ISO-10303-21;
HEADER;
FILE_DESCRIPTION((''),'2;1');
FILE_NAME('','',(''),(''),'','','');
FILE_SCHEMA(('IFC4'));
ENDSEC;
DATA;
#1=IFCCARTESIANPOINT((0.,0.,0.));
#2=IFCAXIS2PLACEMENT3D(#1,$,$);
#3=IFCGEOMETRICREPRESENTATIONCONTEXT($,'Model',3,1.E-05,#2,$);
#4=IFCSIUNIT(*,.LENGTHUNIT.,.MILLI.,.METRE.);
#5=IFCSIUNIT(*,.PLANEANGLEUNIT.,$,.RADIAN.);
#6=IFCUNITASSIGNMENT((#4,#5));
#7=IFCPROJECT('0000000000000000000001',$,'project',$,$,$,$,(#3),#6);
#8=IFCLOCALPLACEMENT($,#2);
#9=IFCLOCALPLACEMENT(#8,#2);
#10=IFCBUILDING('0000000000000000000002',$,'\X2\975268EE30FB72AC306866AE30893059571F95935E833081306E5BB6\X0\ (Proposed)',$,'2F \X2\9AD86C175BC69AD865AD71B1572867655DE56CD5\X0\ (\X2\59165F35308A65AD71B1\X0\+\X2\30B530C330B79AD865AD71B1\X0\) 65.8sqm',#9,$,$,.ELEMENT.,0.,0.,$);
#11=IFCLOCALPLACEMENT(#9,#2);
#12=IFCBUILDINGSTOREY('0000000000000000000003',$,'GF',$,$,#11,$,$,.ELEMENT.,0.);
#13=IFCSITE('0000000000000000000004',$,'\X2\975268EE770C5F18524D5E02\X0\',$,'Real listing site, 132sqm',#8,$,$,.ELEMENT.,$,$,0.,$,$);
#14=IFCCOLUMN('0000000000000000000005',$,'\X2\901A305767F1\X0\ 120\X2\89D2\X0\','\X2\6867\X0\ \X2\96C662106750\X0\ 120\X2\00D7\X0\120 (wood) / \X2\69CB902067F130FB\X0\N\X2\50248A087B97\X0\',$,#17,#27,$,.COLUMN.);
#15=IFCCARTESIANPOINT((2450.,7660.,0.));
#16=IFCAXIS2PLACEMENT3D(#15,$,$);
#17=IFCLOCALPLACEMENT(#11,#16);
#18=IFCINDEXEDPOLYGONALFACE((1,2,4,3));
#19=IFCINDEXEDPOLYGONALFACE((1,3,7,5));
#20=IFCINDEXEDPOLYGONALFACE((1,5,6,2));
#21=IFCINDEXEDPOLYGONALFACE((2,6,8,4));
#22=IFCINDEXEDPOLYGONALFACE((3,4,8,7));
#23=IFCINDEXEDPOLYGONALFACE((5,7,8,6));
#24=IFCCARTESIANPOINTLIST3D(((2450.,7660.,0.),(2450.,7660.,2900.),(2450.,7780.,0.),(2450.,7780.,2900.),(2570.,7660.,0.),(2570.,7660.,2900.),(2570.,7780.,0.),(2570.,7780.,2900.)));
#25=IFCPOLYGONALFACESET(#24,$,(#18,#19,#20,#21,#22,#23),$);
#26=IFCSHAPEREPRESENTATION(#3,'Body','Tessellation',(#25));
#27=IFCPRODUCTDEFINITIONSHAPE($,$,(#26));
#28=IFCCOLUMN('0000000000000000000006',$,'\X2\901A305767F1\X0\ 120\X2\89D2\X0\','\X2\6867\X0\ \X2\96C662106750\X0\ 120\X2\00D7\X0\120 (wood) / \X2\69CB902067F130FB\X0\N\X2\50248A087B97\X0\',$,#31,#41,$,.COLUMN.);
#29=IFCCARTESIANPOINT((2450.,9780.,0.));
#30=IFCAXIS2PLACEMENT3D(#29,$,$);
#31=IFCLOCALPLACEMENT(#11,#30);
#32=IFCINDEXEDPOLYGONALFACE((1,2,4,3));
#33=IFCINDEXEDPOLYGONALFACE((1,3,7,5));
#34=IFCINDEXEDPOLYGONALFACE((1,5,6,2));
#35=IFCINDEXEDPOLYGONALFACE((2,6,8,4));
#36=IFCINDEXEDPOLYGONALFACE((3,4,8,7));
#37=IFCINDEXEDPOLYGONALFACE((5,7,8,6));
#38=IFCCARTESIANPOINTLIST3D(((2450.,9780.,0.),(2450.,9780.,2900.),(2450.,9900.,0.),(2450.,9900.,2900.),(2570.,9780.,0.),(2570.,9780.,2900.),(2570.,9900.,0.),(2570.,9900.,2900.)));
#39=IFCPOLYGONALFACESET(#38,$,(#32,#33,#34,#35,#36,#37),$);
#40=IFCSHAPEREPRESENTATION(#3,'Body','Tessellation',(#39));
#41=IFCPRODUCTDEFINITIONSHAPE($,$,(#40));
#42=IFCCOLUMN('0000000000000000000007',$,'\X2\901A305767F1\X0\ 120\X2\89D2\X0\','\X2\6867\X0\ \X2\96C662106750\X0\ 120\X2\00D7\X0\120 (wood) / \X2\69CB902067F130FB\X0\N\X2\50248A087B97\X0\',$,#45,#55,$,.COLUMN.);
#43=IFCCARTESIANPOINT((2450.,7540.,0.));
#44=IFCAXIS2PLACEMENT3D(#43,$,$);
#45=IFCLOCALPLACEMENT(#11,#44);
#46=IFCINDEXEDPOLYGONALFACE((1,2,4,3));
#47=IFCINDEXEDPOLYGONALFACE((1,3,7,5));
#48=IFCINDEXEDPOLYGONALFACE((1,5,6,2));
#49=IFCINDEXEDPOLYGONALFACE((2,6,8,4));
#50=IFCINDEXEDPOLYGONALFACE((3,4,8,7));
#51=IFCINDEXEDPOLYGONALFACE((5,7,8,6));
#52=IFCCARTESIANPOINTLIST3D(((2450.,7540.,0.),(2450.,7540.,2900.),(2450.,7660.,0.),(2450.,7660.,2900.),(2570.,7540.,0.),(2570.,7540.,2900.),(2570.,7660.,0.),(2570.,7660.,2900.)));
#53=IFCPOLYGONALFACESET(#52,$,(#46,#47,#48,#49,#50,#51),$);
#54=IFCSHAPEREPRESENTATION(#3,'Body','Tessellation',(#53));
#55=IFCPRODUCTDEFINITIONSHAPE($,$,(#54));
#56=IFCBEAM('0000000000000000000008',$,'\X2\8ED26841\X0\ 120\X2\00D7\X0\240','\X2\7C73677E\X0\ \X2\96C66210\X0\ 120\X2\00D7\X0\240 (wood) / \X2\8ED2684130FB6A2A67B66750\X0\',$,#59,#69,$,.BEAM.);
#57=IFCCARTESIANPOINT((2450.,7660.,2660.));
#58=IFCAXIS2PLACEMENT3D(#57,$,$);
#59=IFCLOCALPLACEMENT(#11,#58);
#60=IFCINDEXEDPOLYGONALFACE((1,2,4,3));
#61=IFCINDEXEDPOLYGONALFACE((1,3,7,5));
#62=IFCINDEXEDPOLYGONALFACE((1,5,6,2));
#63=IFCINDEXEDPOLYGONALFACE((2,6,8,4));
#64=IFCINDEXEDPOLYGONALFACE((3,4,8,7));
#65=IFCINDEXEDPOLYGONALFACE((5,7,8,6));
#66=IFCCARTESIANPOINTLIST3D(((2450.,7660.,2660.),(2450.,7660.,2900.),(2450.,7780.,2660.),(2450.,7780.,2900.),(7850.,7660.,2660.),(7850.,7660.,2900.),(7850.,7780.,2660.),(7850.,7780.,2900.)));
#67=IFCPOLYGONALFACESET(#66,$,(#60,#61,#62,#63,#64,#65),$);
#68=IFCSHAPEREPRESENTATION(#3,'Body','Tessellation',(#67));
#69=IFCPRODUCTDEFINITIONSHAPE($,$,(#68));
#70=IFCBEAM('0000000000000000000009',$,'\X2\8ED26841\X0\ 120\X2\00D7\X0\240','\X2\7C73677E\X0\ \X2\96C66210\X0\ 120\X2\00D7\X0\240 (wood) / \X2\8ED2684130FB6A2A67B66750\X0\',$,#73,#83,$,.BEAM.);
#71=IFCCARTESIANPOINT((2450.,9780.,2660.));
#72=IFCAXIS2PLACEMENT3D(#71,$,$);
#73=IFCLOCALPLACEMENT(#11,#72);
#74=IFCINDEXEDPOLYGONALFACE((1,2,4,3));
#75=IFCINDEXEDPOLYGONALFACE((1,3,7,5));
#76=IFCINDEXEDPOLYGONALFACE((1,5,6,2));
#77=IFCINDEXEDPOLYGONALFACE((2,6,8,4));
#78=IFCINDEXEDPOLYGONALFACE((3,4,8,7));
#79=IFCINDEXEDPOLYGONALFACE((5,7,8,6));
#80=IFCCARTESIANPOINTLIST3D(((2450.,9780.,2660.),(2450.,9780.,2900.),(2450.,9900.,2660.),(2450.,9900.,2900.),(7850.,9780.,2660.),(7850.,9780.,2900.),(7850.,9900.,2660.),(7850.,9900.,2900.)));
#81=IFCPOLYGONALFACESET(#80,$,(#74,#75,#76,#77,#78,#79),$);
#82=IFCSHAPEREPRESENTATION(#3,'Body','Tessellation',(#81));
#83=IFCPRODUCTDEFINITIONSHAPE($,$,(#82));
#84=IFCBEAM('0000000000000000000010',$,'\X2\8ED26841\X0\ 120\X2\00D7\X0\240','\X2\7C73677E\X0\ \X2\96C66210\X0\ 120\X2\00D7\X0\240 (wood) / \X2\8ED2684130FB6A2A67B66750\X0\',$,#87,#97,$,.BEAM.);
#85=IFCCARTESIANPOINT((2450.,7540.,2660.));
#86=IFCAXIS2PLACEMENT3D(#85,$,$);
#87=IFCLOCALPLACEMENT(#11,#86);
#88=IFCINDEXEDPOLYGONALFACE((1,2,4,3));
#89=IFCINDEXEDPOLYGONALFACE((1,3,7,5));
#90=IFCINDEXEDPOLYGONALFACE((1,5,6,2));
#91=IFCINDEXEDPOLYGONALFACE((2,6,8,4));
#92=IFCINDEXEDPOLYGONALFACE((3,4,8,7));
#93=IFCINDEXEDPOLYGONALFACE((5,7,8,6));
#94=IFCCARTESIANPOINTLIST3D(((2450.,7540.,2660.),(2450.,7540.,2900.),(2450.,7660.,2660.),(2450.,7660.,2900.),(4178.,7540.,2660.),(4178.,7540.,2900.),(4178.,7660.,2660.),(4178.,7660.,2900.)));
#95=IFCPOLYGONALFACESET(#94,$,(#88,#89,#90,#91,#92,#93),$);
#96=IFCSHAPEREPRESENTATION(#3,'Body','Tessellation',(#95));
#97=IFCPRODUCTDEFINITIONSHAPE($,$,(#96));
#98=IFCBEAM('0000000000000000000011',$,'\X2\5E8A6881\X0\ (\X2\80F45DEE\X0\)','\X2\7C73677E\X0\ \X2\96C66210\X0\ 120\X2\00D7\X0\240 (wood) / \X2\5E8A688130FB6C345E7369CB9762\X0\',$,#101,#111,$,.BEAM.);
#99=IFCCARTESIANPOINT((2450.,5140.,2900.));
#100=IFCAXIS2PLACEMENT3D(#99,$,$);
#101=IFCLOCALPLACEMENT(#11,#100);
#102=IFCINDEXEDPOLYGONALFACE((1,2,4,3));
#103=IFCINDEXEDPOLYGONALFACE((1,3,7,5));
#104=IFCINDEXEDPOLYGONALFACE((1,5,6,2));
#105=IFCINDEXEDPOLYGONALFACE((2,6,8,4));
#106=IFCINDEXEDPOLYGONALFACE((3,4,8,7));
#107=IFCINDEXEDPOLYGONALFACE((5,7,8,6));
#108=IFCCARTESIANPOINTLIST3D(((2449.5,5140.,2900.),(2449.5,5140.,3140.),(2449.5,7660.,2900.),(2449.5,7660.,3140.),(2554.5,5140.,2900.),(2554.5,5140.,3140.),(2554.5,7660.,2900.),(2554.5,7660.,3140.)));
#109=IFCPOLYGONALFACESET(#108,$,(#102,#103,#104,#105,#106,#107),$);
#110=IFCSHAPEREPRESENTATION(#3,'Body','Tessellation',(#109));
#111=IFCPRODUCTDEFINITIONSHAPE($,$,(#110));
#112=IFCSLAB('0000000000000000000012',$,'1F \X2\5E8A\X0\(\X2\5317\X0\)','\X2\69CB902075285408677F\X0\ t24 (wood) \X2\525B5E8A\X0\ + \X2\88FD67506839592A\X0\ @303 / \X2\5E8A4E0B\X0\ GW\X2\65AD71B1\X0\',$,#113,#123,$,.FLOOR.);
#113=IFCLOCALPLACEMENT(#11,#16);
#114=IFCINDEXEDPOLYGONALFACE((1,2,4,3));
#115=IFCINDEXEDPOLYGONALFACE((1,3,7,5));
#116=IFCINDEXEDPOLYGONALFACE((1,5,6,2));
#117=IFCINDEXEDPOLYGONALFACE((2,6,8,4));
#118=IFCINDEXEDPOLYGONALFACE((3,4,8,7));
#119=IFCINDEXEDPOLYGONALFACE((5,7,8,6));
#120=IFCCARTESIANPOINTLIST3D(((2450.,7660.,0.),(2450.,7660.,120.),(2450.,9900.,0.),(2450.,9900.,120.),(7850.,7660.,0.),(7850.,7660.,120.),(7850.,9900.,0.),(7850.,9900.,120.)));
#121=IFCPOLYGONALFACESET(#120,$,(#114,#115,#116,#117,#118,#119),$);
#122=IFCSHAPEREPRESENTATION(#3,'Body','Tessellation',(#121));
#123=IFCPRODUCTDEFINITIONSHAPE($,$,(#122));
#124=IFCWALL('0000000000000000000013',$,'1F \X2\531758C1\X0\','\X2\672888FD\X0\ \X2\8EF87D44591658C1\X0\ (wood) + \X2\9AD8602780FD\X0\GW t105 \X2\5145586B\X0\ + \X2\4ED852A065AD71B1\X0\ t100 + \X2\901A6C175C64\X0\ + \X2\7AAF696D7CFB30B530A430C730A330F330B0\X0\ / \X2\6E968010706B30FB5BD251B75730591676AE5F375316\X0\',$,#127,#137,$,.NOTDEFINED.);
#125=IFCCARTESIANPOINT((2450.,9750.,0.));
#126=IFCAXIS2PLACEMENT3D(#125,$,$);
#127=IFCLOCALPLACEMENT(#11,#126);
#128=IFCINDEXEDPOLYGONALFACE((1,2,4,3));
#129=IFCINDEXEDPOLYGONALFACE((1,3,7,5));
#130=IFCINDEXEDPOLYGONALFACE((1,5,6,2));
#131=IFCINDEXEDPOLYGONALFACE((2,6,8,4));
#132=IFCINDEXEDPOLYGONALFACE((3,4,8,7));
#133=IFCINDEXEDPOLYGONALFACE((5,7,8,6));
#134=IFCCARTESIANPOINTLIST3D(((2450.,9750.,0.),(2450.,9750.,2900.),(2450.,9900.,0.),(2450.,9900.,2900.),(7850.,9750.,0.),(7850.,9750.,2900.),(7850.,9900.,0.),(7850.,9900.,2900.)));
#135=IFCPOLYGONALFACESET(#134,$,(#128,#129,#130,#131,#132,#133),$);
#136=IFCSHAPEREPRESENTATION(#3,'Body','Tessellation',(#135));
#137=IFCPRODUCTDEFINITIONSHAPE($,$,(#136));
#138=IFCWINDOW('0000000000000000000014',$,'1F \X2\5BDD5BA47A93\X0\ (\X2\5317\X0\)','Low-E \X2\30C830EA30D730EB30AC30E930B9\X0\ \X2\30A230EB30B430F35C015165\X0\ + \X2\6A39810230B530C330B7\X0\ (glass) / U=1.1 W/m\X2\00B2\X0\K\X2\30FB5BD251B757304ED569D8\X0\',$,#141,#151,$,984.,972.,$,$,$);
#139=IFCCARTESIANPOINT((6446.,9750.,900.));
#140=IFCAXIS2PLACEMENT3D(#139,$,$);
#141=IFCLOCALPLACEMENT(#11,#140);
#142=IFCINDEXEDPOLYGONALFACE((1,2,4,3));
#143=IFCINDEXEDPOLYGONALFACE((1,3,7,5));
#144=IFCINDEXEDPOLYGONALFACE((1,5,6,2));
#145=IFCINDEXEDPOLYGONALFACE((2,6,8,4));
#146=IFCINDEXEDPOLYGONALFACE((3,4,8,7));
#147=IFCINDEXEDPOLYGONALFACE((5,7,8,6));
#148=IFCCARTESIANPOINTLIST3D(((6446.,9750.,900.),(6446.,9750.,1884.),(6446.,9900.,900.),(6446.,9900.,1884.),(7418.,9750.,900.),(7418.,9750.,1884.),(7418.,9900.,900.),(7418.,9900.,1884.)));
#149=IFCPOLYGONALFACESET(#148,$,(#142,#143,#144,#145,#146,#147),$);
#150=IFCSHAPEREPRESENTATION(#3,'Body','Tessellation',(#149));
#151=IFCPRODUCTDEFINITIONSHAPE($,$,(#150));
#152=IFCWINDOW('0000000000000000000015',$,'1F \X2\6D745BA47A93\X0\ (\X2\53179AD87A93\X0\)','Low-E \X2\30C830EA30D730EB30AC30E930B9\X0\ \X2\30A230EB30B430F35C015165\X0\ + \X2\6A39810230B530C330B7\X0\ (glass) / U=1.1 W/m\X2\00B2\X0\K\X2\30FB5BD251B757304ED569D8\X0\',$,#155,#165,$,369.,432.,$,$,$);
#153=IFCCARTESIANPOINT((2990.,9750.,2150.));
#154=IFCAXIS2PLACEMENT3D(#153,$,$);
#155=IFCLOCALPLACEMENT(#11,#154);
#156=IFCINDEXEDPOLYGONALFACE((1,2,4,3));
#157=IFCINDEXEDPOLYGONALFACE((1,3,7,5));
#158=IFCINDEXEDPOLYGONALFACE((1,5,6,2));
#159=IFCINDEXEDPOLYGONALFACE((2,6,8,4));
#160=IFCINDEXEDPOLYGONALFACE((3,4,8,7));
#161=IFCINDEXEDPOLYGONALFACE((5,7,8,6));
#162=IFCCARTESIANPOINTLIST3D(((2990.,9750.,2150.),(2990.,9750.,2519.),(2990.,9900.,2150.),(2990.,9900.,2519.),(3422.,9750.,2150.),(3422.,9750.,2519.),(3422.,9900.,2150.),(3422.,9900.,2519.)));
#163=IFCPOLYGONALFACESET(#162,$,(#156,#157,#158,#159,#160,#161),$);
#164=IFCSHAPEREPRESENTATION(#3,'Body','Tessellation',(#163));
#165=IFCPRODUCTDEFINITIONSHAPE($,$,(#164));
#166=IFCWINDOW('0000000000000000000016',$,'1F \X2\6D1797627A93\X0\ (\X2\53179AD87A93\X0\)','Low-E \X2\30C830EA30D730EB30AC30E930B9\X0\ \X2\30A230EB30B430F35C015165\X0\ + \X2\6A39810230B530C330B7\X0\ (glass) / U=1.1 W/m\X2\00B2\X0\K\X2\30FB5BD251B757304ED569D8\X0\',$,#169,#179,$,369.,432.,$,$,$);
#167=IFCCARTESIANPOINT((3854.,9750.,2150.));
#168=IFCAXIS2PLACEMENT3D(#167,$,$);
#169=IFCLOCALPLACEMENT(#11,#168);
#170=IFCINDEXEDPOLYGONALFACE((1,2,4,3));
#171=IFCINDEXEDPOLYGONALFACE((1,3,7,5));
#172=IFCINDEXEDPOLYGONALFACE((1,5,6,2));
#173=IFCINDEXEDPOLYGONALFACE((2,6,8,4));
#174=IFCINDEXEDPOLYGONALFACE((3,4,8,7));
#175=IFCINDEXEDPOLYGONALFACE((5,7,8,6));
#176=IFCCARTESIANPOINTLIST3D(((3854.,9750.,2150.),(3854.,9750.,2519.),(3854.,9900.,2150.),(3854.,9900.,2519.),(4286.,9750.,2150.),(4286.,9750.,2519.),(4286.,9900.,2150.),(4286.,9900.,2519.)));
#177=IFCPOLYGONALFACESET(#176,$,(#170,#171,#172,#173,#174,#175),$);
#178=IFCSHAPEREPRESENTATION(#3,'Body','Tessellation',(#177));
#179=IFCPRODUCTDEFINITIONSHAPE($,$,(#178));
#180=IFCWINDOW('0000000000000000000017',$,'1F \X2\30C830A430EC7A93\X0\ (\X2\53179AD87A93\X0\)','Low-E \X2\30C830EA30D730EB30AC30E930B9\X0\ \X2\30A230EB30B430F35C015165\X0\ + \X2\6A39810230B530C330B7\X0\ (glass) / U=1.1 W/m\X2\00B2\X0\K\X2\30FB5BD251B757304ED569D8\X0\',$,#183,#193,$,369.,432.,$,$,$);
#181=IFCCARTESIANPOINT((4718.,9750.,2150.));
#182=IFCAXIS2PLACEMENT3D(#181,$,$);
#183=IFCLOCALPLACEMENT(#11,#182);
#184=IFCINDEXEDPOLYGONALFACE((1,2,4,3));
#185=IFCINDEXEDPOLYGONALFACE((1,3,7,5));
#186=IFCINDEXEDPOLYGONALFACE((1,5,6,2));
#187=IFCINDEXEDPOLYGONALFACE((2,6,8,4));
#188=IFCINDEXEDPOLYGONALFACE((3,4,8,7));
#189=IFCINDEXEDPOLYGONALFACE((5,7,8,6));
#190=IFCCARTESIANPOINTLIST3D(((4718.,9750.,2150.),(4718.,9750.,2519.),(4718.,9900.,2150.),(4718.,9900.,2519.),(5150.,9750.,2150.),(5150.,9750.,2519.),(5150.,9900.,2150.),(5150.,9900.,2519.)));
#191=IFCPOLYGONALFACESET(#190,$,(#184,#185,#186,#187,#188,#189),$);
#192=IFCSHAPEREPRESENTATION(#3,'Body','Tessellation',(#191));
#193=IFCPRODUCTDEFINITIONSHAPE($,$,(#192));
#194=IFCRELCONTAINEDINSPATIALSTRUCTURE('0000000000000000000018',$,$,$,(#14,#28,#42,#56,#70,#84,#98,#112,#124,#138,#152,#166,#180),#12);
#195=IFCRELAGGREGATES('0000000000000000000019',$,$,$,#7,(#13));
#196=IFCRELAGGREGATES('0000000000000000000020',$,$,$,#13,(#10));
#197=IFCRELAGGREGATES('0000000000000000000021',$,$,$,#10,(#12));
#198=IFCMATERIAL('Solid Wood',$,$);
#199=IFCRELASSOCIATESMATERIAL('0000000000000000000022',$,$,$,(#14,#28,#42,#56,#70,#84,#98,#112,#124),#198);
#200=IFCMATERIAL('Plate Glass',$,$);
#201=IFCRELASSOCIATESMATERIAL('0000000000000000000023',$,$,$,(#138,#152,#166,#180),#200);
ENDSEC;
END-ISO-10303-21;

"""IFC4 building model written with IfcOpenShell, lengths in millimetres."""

from ifc_helpers import new_model, si_unit, frame, frame_2d, origin, place, context, project, spatial, rectangle, extrude, material, element, fill, save


model = new_model("IFC4")

# Units and contexts
model_context = context("Model", 3, precision=1e-05, world=origin())
ifc_project = project(units=[si_unit("LENGTHUNIT", "METRE", prefix="MILLI"), si_unit("PLANEANGLEUNIT", "RADIAN")], contexts=[model_context])

# Site, building, storey
site_placement = place(None, origin())
site = spatial("IfcSite", under=ifc_project, at=site_placement, Name="青森県弘前市", ObjectType="Real listing site, 132sqm", CompositionType="ELEMENT", RefElevation=0.0)
building_placement = place(site_placement, origin())
building = spatial("IfcBuilding", under=site, at=building_placement, Name="青森・犬と暮らす土間広めの家 (Proposed)", ObjectType="2F 高気密高断熱在来工法 (外張り断熱+サッシ高断熱) 65.8sqm", CompositionType="ELEMENT", ElevationOfRefHeight=0.0, ElevationOfTerrain=0.0)
storey_placement = place(building_placement, origin())
storey = spatial("IfcBuildingStorey", under=building, at=storey_placement, Name="GF", CompositionType="ELEMENT", Elevation=0.0)

# Columns
ifc_material_1 = material(Name="Solid Wood")
column_1_placement = place(storey_placement, frame((2450.0, 7660.0, 0.0)))
element("IfcColumn", 1, at=column_1_placement, inside=storey, material=ifc_material_1, Name="通し柱 120角", Description="桧 集成材 120×120 (wood) / 構造柱・N値計算", PredefinedType="COLUMN", context=model_context, shape_type="SweptSolid", body=[
    extrude(rectangle(XDim=120.0, YDim=120.0, at=frame_2d((60.0, 60.0))), frame((2450.0, 7660.0, 0.0)), (0.0, 0.0, 1.0), 2900.0),
])
column_2_placement = place(storey_placement, frame((2450.0, 9780.0, 0.0)))
element("IfcColumn", 2, at=column_2_placement, inside=storey, material=ifc_material_1, Name="通し柱 120角", Description="桧 集成材 120×120 (wood) / 構造柱・N値計算", PredefinedType="COLUMN", context=model_context, shape_type="SweptSolid", body=[
    extrude(rectangle(XDim=120.0, YDim=120.0, at=frame_2d((60.0, 60.0))), frame((2450.0, 9780.0, 0.0)), (0.0, 0.0, 1.0), 2900.0),
])
column_3_placement = place(storey_placement, frame((2450.0, 7540.0, 0.0)))
element("IfcColumn", 3, at=column_3_placement, inside=storey, material=ifc_material_1, Name="通し柱 120角", Description="桧 集成材 120×120 (wood) / 構造柱・N値計算", PredefinedType="COLUMN", context=model_context, shape_type="SweptSolid", body=[
    extrude(rectangle(XDim=120.0, YDim=120.0, at=frame_2d((60.0, 60.0))), frame((2450.0, 7540.0, 0.0)), (0.0, 0.0, 1.0), 2900.0),
])

# Beams
beam_1_placement = place(storey_placement, frame((2450.0, 7660.0, 2660.0)))
element("IfcBeam", 4, at=beam_1_placement, inside=storey, material=ifc_material_1, Name="軒桁 120×240", Description="米松 集成 120×240 (wood) / 軒桁・横架材", PredefinedType="BEAM", context=model_context, shape_type="SweptSolid", body=[
    extrude(rectangle(XDim=5400.0, YDim=120.0, at=frame_2d((2700.0, 60.0))), frame((2450.0, 7660.0, 2660.0)), (0.0, 0.0, 1.0), 240.0),
])
beam_2_placement = place(storey_placement, frame((2450.0, 9780.0, 2660.0)))
element("IfcBeam", 5, at=beam_2_placement, inside=storey, material=ifc_material_1, Name="軒桁 120×240", Description="米松 集成 120×240 (wood) / 軒桁・横架材", PredefinedType="BEAM", context=model_context, shape_type="SweptSolid", body=[
    extrude(rectangle(XDim=5400.0, YDim=120.0, at=frame_2d((2700.0, 60.0))), frame((2450.0, 9780.0, 2660.0)), (0.0, 0.0, 1.0), 240.0),
])
beam_3_placement = place(storey_placement, frame((2450.0, 7540.0, 2660.0)))
element("IfcBeam", 6, at=beam_3_placement, inside=storey, material=ifc_material_1, Name="軒桁 120×240", Description="米松 集成 120×240 (wood) / 軒桁・横架材", PredefinedType="BEAM", context=model_context, shape_type="SweptSolid", body=[
    extrude(rectangle(XDim=1728.0, YDim=120.0, at=frame_2d((864.0, 60.0))), frame((2450.0, 7540.0, 2660.0)), (0.0, 0.0, 1.0), 240.0),
])
beam_4_placement = place(storey_placement, frame((2450.0, 5140.0, 2900.0)))
element("IfcBeam", 7, at=beam_4_placement, inside=storey, material=ifc_material_1, Name="床梁 (胴差)", Description="米松 集成 120×240 (wood) / 床梁・水平構面", PredefinedType="BEAM", context=model_context, shape_type="SweptSolid", body=[
    extrude(rectangle(XDim=105.0, YDim=2520.0, at=frame_2d((52.0, 1260.0))), frame((2450.0, 5140.0, 2900.0)), (0.0, 0.0, 1.0), 240.0),
])

# Slab
slab_placement = place(storey_placement, frame((2450.0, 7660.0, 0.0)))
element("IfcSlab", 8, at=slab_placement, inside=storey, material=ifc_material_1, Name="1F 床(北)", Description="構造用合板 t24 (wood) 剛床 + 製材根太 @303 / 床下 GW断熱", PredefinedType="FLOOR", context=model_context, shape_type="SweptSolid", body=[
    extrude(rectangle(XDim=5400.0, YDim=2240.0, at=frame_2d((2700.0, 1120.0))), frame((2450.0, 7660.0, 0.0)), (0.0, 0.0, 1.0), 120.0),
])

# Wall, openings, windows
wall_1_placement = place(storey_placement, frame((2450.0, 9750.0, 0.0)))
wall_1 = element("IfcWall", 9, at=wall_1_placement, inside=storey, material=ifc_material_1, Name="1F 北壁", Description="木製 軸組外壁 (wood) + 高性能GW t105 充填 + 付加断熱 t100 + 通気層 + 窯業系サイディング / 準耐火・寒冷地外皮強化", PredefinedType="NOTDEFINED", context=model_context, shape_type="SweptSolid", body=[
    extrude(rectangle(XDim=5400.0, YDim=150.0, at=frame_2d((2700.0, 75.0))), frame((2450.0, 9750.0, 0.0)), (0.0, 0.0, 1.0), 2900.0),
])
opening_1_placement = place(storey_placement, frame((6446.0, 9750.0, 900.0)))
opening_1 = element("IfcOpeningElement", 10, at=opening_1_placement, cuts=wall_1, PredefinedType="NOTDEFINED", context=model_context, shape_type="SweptSolid", body=[
    extrude(rectangle(XDim=972.0, YDim=150.0, at=frame_2d((486.0, 75.0))), frame((6446.0, 9750.0, 900.0)), (0.0, 0.0, 1.0), 984.0),
])
opening_2_placement = place(storey_placement, frame((2990.0, 9750.0, 2150.0)))
opening_2 = element("IfcOpeningElement", 11, at=opening_2_placement, cuts=wall_1, PredefinedType="NOTDEFINED", context=model_context, shape_type="SweptSolid", body=[
    extrude(rectangle(XDim=432.0, YDim=150.0, at=frame_2d((216.0, 75.0))), frame((2990.0, 9750.0, 2150.0)), (0.0, 0.0, 1.0), 369.0),
])
opening_3_placement = place(storey_placement, frame((3854.0, 9750.0, 2150.0)))
opening_3 = element("IfcOpeningElement", 12, at=opening_3_placement, cuts=wall_1, PredefinedType="NOTDEFINED", context=model_context, shape_type="SweptSolid", body=[
    extrude(rectangle(XDim=432.0, YDim=150.0, at=frame_2d((216.0, 75.0))), frame((3854.0, 9750.0, 2150.0)), (0.0, 0.0, 1.0), 369.0),
])
opening_4_placement = place(storey_placement, frame((4718.0, 9750.0, 2150.0)))
opening_4 = element("IfcOpeningElement", 13, at=opening_4_placement, cuts=wall_1, PredefinedType="NOTDEFINED", context=model_context, shape_type="SweptSolid", body=[
    extrude(rectangle(XDim=432.0, YDim=150.0, at=frame_2d((216.0, 75.0))), frame((4718.0, 9750.0, 2150.0)), (0.0, 0.0, 1.0), 369.0),
])
ifc_material_2 = material(Name="Plate Glass")
window_1_placement = place(storey_placement, frame((6446.0, 9750.0, 900.0)))
window_1 = element("IfcWindow", 14, at=window_1_placement, inside=storey, material=ifc_material_2, Name="1F 寝室窓 (北)", Description="Low-E トリプルガラス アルゴン封入 + 樹脂サッシ (glass) / U=1.1 W/m²K・寒冷地仕様", OverallHeight=984.0, OverallWidth=972.0, context=model_context, shape_type="SweptSolid", body=[
    extrude(rectangle(XDim=972.0, YDim=150.0, at=frame_2d((486.0, 75.0))), frame((6446.0, 9750.0, 900.0)), (0.0, 0.0, 1.0), 984.0),
])
fill(opening_1, window_1)
window_2_placement = place(storey_placement, frame((2990.0, 9750.0, 2150.0)))
window_2 = element("IfcWindow", 15, at=window_2_placement, inside=storey, material=ifc_material_2, Name="1F 浴室窓 (北高窓)", Description="Low-E トリプルガラス アルゴン封入 + 樹脂サッシ (glass) / U=1.1 W/m²K・寒冷地仕様", OverallHeight=369.0, OverallWidth=432.0, context=model_context, shape_type="SweptSolid", body=[
    extrude(rectangle(XDim=432.0, YDim=150.0, at=frame_2d((216.0, 75.0))), frame((2990.0, 9750.0, 2150.0)), (0.0, 0.0, 1.0), 369.0),
])
fill(opening_2, window_2)
window_3_placement = place(storey_placement, frame((3854.0, 9750.0, 2150.0)))
window_3 = element("IfcWindow", 16, at=window_3_placement, inside=storey, material=ifc_material_2, Name="1F 洗面窓 (北高窓)", Description="Low-E トリプルガラス アルゴン封入 + 樹脂サッシ (glass) / U=1.1 W/m²K・寒冷地仕様", OverallHeight=369.0, OverallWidth=432.0, context=model_context, shape_type="SweptSolid", body=[
    extrude(rectangle(XDim=432.0, YDim=150.0, at=frame_2d((216.0, 75.0))), frame((3854.0, 9750.0, 2150.0)), (0.0, 0.0, 1.0), 369.0),
])
fill(opening_3, window_3)
window_4_placement = place(storey_placement, frame((4718.0, 9750.0, 2150.0)))
window_4 = element("IfcWindow", 17, at=window_4_placement, inside=storey, material=ifc_material_2, Name="1F トイレ窓 (北高窓)", Description="Low-E トリプルガラス アルゴン封入 + 樹脂サッシ (glass) / U=1.1 W/m²K・寒冷地仕様", OverallHeight=369.0, OverallWidth=432.0, context=model_context, shape_type="SweptSolid", body=[
    extrude(rectangle(XDim=432.0, YDim=150.0, at=frame_2d((216.0, 75.0))), frame((4718.0, 9750.0, 2150.0)), (0.0, 0.0, 1.0), 369.0),
])
fill(opening_4, window_4)

save(model, "model.ifc")
